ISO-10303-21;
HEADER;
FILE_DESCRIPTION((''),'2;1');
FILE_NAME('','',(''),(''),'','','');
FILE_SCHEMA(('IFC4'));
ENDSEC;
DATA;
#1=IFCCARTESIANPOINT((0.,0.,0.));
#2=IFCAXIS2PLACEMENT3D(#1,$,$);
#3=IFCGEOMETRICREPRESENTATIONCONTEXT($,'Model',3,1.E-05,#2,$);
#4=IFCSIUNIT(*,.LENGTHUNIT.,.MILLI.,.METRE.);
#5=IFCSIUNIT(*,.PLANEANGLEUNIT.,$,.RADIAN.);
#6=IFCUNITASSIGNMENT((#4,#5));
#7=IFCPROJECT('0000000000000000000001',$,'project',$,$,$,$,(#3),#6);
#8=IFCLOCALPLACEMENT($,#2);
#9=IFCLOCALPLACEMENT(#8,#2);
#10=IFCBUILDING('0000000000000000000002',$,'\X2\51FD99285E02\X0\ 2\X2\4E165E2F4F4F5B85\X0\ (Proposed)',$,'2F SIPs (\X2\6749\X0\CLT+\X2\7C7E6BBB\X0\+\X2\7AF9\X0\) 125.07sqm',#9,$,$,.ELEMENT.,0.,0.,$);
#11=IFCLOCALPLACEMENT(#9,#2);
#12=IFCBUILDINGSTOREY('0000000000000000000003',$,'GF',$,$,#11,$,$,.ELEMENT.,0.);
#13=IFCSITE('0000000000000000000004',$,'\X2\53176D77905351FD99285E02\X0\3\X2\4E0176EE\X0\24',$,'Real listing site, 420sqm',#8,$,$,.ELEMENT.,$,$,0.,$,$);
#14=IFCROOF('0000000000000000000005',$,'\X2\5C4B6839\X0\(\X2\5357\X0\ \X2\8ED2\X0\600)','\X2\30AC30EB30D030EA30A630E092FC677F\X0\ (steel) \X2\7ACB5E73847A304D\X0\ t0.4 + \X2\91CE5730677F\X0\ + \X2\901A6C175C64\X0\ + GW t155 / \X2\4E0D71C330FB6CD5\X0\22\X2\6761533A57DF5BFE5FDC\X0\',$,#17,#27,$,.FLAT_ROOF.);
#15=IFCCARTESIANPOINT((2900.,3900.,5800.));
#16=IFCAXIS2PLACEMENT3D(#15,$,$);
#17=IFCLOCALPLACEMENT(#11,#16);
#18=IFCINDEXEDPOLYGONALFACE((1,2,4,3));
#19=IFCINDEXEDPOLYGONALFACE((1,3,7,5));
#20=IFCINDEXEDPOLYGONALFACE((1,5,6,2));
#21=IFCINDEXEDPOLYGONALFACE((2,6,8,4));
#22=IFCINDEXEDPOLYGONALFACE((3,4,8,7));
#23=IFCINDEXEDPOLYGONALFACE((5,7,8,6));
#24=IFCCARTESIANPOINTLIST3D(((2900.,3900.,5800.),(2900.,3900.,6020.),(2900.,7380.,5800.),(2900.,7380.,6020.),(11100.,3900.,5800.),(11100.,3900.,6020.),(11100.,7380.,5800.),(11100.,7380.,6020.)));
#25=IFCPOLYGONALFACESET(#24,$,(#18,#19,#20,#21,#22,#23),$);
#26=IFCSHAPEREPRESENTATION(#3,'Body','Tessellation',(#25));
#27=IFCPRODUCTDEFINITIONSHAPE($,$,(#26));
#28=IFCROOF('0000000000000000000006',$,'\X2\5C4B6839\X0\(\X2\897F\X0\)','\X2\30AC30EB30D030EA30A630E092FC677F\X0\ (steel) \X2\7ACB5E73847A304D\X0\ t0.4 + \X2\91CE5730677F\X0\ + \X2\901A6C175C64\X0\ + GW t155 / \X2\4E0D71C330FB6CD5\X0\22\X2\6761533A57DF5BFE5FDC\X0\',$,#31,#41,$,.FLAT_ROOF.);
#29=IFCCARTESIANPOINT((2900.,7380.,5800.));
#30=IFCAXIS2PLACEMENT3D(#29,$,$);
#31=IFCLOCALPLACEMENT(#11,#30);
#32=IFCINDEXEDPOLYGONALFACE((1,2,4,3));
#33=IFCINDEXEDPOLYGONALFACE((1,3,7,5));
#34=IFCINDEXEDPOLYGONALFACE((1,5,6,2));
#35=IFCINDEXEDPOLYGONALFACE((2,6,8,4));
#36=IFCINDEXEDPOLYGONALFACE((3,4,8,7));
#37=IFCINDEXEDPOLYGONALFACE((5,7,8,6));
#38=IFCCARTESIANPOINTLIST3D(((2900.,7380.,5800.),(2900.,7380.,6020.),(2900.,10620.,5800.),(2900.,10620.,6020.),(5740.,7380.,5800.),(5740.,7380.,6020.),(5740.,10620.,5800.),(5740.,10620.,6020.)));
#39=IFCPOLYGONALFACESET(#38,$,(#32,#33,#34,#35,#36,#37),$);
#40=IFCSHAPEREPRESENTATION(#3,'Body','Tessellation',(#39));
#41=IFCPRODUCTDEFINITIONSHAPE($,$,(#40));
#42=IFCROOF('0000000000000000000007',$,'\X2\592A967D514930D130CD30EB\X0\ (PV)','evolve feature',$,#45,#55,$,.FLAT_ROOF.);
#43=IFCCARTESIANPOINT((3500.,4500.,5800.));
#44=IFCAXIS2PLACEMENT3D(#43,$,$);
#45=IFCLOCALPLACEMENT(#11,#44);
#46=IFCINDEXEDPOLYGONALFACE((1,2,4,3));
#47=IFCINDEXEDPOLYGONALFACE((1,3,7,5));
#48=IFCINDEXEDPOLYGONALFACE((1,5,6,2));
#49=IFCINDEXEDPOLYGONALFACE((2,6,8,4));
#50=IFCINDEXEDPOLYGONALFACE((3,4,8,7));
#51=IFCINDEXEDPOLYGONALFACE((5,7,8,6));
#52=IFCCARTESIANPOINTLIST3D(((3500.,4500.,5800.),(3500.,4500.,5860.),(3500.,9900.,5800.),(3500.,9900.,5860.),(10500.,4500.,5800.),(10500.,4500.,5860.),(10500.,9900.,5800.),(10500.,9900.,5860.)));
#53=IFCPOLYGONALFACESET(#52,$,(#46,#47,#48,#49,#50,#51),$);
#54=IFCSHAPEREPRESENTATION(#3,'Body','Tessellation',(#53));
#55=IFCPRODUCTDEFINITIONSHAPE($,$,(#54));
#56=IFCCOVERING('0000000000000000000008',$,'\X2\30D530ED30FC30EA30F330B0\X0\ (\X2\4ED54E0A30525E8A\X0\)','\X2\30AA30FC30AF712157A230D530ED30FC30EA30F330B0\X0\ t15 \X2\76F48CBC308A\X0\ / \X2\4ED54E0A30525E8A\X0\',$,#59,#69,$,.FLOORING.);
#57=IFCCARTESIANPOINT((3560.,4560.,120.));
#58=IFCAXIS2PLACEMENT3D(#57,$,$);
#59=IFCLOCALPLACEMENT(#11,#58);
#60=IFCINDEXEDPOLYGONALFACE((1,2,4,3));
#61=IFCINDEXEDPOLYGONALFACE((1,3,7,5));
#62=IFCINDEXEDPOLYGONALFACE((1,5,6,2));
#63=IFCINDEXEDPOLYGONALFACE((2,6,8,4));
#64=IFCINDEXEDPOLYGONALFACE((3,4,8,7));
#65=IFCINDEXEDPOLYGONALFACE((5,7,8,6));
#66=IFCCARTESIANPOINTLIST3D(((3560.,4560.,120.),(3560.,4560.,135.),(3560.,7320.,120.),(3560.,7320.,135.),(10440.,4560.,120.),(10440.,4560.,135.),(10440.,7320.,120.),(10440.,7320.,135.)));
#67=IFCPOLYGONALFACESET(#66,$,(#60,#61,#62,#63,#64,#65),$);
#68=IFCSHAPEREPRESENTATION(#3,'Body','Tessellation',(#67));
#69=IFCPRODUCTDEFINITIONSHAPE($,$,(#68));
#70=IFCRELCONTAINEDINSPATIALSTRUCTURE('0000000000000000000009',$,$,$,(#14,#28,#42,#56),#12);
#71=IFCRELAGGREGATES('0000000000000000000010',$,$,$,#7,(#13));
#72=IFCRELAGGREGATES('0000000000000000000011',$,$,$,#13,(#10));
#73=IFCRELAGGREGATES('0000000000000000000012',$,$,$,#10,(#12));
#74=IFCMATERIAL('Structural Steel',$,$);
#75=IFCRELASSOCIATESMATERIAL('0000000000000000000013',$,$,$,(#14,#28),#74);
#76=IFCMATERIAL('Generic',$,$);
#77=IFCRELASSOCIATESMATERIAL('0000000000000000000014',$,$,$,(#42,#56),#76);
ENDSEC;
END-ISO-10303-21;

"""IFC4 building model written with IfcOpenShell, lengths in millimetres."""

from ifc_helpers import new_model, si_unit, frame, frame_2d, origin, place, context, project, spatial, rectangle, extrude, material, element, save


model = new_model("IFC4")

# Units and contexts
model_context = context("Model", 3, precision=1e-05, world=origin())
ifc_project = project(units=[si_unit("LENGTHUNIT", "METRE", prefix="MILLI"), si_unit("PLANEANGLEUNIT", "RADIAN")], contexts=[model_context])

# Site, building, storey
site_placement = place(None, origin())
site = spatial("IfcSite", under=ifc_project, at=site_placement, Name="北海道函館市3丁目24", ObjectType="Real listing site, 420sqm", CompositionType="ELEMENT", RefElevation=0.0)
building_placement = place(site_placement, origin())
building = spatial("IfcBuilding", under=site, at=building_placement, Name="函館市 2世帯住宅 (Proposed)", ObjectType="2F SIPs (杉CLT+籾殻+竹) 125.07sqm", CompositionType="ELEMENT", ElevationOfRefHeight=0.0, ElevationOfTerrain=0.0)
storey_placement = place(building_placement, origin())
storey = spatial("IfcBuildingStorey", under=building, at=storey_placement, Name="GF", CompositionType="ELEMENT", Elevation=0.0)

# Shared definitions
ifc_material_1 = material(Name="Generic")

# Roofs
ifc_material_2 = material(Name="Structural Steel")
roof_1_placement = place(storey_placement, frame((2900.0, 3900.0, 5800.0)))
element("IfcRoof", 1, at=roof_1_placement, inside=storey, material=ifc_material_2, Name="屋根(南 軒600)", Description="ガルバリウム鋼板 (steel) 立平葺き t0.4 + 野地板 + 通気層 + GW t155 / 不燃・法22条区域対応", PredefinedType="FLAT_ROOF", context=model_context, shape_type="SweptSolid", body=[
    extrude(rectangle(XDim=8200.0, YDim=3480.0, at=frame_2d((4100.0, 1740.0))), frame((2900.0, 3900.0, 5800.0)), (0.0, 0.0, 1.0), 220.0),
])
roof_2_placement = place(storey_placement, frame((2900.0, 7380.0, 5800.0)))
element("IfcRoof", 2, at=roof_2_placement, inside=storey, material=ifc_material_2, Name="屋根(西)", Description="ガルバリウム鋼板 (steel) 立平葺き t0.4 + 野地板 + 通気層 + GW t155 / 不燃・法22条区域対応", PredefinedType="FLAT_ROOF", context=model_context, shape_type="SweptSolid", body=[
    extrude(rectangle(XDim=2840.0, YDim=3240.0, at=frame_2d((1420.0, 1620.0))), frame((2900.0, 7380.0, 5800.0)), (0.0, 0.0, 1.0), 220.0),
])
roof_3_placement = place(storey_placement, frame((3500.0, 4500.0, 5800.0)))
element("IfcRoof", 3, at=roof_3_placement, inside=storey, material=ifc_material_1, Name="太陽光パネル (PV)", Description="evolve feature", PredefinedType="FLAT_ROOF", context=model_context, shape_type="SweptSolid", body=[
    extrude(rectangle(XDim=7000.0, YDim=5400.0, at=frame_2d((3500.0, 2700.0))), frame((3500.0, 4500.0, 5800.0)), (0.0, 0.0, 1.0), 60.0),
])

# Covering
covering_placement = place(storey_placement, frame((3560.0, 4560.0, 120.0)))
element("IfcCovering", 4, at=covering_placement, inside=storey, material=ifc_material_1, Name="フローリング (仕上げ床)", Description="オーク無垢フローリング t15 直貼り / 仕上げ床", PredefinedType="FLOORING", context=model_context, shape_type="SweptSolid", body=[
    extrude(rectangle(XDim=6880.0, YDim=2760.0, at=frame_2d((3440.0, 1380.0))), frame((3560.0, 4560.0, 120.0)), (0.0, 0.0, 1.0), 15.0),
])

save(model, "model.ifc")
